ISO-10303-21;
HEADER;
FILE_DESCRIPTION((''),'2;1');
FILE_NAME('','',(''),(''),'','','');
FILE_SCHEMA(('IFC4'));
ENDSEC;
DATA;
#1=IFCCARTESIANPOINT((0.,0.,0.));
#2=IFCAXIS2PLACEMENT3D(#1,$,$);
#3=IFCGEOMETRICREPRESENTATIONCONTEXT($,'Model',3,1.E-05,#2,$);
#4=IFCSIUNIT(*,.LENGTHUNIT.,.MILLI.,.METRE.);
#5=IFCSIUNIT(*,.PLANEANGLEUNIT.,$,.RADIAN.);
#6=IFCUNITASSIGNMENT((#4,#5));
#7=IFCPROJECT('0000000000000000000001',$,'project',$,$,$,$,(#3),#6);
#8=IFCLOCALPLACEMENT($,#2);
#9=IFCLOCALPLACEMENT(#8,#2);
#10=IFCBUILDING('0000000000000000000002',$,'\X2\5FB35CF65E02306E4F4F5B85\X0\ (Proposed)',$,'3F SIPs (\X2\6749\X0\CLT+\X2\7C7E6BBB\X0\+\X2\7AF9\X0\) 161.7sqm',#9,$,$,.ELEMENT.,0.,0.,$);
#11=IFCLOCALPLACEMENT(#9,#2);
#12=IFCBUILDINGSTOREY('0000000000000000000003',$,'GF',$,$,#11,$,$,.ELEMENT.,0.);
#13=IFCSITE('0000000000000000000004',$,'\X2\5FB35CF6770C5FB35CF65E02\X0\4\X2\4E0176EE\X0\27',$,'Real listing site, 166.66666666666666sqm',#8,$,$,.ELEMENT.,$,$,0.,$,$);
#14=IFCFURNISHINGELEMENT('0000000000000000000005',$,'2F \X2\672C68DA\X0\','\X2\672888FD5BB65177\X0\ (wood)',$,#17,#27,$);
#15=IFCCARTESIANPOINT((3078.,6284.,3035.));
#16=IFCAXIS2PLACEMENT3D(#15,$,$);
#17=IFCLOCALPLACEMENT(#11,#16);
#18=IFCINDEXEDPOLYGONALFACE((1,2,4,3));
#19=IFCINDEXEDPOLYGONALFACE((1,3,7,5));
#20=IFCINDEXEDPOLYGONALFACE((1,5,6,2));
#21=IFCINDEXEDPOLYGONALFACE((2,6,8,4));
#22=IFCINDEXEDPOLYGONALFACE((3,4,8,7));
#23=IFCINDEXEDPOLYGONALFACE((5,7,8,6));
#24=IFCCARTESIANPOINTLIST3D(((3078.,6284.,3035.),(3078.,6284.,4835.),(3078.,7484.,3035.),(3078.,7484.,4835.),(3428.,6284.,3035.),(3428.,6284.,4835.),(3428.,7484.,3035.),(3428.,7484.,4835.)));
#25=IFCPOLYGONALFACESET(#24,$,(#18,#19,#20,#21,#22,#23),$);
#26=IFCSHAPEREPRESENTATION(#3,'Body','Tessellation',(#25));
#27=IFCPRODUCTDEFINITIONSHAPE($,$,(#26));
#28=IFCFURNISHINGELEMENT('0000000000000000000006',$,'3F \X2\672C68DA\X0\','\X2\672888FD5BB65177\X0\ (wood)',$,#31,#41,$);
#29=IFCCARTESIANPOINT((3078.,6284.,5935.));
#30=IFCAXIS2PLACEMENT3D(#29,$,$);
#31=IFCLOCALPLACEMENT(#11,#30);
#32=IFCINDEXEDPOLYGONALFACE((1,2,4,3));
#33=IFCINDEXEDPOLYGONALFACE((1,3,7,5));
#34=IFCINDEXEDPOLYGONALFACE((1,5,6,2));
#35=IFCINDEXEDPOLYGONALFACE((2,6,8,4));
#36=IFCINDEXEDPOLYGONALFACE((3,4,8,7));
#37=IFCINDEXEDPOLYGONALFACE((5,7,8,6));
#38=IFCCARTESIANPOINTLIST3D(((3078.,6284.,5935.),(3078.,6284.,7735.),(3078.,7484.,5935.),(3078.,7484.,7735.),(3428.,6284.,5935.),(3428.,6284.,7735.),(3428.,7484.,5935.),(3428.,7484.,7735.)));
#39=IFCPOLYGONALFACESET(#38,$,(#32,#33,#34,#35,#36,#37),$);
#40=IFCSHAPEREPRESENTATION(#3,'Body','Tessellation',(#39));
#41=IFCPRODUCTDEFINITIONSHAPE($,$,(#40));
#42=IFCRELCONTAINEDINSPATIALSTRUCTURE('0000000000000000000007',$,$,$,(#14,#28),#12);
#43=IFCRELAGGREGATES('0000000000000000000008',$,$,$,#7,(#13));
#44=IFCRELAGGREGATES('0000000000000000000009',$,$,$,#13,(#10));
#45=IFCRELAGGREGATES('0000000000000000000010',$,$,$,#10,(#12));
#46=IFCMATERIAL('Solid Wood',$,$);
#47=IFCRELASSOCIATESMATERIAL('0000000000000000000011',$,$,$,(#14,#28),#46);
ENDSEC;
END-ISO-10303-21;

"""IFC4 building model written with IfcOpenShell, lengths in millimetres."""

from ifc_helpers import new_model, si_unit, frame, frame_2d, origin, place, context, project, spatial, rectangle, extrude, material, element, save


model = new_model("IFC4")

# Units and contexts
model_context = context("Model", 3, precision=1e-05, world=origin())
ifc_project = project(units=[si_unit("LENGTHUNIT", "METRE", prefix="MILLI"), si_unit("PLANEANGLEUNIT", "RADIAN")], contexts=[model_context])

# Site, building, storey
site_placement = place(None, origin())
site = spatial("IfcSite", under=ifc_project, at=site_placement, Name="徳島県徳島市4丁目27", ObjectType="Real listing site, 166.66666666666666sqm", CompositionType="ELEMENT", RefElevation=0.0)
building_placement = place(site_placement, origin())
building = spatial("IfcBuilding", under=site, at=building_placement, Name="徳島市の住宅 (Proposed)", ObjectType="3F SIPs (杉CLT+籾殻+竹) 161.7sqm", CompositionType="ELEMENT", ElevationOfRefHeight=0.0, ElevationOfTerrain=0.0)
storey_placement = place(building_placement, origin())
storey = spatial("IfcBuildingStorey", under=building, at=storey_placement, Name="GF", CompositionType="ELEMENT", Elevation=0.0)

# Shared definitions
ifc_material_1 = material(Name="Solid Wood")

# Furnishing elements
furnishing_1_placement = place(storey_placement, frame((3078.0, 6284.0, 3035.0)))
element("IfcFurnishingElement", 1, at=furnishing_1_placement, inside=storey, material=ifc_material_1, Name="2F 本棚", Description="木製家具 (wood)", context=model_context, shape_type="SweptSolid", body=[
    extrude(rectangle(XDim=350.0, YDim=1200.0, at=frame_2d((175.0, 600.0))), frame((3078.0, 6284.0, 3035.0)), (0.0, 0.0, 1.0), 1800.0),
])
furnishing_2_placement = place(storey_placement, frame((3078.0, 6284.0, 5935.0)))
element("IfcFurnishingElement", 2, at=furnishing_2_placement, inside=storey, material=ifc_material_1, Name="3F 本棚", Description="木製家具 (wood)", context=model_context, shape_type="SweptSolid", body=[
    extrude(rectangle(XDim=350.0, YDim=1200.0, at=frame_2d((175.0, 600.0))), frame((3078.0, 6284.0, 5935.0)), (0.0, 0.0, 1.0), 1800.0),
])

save(model, "model.ifc")
